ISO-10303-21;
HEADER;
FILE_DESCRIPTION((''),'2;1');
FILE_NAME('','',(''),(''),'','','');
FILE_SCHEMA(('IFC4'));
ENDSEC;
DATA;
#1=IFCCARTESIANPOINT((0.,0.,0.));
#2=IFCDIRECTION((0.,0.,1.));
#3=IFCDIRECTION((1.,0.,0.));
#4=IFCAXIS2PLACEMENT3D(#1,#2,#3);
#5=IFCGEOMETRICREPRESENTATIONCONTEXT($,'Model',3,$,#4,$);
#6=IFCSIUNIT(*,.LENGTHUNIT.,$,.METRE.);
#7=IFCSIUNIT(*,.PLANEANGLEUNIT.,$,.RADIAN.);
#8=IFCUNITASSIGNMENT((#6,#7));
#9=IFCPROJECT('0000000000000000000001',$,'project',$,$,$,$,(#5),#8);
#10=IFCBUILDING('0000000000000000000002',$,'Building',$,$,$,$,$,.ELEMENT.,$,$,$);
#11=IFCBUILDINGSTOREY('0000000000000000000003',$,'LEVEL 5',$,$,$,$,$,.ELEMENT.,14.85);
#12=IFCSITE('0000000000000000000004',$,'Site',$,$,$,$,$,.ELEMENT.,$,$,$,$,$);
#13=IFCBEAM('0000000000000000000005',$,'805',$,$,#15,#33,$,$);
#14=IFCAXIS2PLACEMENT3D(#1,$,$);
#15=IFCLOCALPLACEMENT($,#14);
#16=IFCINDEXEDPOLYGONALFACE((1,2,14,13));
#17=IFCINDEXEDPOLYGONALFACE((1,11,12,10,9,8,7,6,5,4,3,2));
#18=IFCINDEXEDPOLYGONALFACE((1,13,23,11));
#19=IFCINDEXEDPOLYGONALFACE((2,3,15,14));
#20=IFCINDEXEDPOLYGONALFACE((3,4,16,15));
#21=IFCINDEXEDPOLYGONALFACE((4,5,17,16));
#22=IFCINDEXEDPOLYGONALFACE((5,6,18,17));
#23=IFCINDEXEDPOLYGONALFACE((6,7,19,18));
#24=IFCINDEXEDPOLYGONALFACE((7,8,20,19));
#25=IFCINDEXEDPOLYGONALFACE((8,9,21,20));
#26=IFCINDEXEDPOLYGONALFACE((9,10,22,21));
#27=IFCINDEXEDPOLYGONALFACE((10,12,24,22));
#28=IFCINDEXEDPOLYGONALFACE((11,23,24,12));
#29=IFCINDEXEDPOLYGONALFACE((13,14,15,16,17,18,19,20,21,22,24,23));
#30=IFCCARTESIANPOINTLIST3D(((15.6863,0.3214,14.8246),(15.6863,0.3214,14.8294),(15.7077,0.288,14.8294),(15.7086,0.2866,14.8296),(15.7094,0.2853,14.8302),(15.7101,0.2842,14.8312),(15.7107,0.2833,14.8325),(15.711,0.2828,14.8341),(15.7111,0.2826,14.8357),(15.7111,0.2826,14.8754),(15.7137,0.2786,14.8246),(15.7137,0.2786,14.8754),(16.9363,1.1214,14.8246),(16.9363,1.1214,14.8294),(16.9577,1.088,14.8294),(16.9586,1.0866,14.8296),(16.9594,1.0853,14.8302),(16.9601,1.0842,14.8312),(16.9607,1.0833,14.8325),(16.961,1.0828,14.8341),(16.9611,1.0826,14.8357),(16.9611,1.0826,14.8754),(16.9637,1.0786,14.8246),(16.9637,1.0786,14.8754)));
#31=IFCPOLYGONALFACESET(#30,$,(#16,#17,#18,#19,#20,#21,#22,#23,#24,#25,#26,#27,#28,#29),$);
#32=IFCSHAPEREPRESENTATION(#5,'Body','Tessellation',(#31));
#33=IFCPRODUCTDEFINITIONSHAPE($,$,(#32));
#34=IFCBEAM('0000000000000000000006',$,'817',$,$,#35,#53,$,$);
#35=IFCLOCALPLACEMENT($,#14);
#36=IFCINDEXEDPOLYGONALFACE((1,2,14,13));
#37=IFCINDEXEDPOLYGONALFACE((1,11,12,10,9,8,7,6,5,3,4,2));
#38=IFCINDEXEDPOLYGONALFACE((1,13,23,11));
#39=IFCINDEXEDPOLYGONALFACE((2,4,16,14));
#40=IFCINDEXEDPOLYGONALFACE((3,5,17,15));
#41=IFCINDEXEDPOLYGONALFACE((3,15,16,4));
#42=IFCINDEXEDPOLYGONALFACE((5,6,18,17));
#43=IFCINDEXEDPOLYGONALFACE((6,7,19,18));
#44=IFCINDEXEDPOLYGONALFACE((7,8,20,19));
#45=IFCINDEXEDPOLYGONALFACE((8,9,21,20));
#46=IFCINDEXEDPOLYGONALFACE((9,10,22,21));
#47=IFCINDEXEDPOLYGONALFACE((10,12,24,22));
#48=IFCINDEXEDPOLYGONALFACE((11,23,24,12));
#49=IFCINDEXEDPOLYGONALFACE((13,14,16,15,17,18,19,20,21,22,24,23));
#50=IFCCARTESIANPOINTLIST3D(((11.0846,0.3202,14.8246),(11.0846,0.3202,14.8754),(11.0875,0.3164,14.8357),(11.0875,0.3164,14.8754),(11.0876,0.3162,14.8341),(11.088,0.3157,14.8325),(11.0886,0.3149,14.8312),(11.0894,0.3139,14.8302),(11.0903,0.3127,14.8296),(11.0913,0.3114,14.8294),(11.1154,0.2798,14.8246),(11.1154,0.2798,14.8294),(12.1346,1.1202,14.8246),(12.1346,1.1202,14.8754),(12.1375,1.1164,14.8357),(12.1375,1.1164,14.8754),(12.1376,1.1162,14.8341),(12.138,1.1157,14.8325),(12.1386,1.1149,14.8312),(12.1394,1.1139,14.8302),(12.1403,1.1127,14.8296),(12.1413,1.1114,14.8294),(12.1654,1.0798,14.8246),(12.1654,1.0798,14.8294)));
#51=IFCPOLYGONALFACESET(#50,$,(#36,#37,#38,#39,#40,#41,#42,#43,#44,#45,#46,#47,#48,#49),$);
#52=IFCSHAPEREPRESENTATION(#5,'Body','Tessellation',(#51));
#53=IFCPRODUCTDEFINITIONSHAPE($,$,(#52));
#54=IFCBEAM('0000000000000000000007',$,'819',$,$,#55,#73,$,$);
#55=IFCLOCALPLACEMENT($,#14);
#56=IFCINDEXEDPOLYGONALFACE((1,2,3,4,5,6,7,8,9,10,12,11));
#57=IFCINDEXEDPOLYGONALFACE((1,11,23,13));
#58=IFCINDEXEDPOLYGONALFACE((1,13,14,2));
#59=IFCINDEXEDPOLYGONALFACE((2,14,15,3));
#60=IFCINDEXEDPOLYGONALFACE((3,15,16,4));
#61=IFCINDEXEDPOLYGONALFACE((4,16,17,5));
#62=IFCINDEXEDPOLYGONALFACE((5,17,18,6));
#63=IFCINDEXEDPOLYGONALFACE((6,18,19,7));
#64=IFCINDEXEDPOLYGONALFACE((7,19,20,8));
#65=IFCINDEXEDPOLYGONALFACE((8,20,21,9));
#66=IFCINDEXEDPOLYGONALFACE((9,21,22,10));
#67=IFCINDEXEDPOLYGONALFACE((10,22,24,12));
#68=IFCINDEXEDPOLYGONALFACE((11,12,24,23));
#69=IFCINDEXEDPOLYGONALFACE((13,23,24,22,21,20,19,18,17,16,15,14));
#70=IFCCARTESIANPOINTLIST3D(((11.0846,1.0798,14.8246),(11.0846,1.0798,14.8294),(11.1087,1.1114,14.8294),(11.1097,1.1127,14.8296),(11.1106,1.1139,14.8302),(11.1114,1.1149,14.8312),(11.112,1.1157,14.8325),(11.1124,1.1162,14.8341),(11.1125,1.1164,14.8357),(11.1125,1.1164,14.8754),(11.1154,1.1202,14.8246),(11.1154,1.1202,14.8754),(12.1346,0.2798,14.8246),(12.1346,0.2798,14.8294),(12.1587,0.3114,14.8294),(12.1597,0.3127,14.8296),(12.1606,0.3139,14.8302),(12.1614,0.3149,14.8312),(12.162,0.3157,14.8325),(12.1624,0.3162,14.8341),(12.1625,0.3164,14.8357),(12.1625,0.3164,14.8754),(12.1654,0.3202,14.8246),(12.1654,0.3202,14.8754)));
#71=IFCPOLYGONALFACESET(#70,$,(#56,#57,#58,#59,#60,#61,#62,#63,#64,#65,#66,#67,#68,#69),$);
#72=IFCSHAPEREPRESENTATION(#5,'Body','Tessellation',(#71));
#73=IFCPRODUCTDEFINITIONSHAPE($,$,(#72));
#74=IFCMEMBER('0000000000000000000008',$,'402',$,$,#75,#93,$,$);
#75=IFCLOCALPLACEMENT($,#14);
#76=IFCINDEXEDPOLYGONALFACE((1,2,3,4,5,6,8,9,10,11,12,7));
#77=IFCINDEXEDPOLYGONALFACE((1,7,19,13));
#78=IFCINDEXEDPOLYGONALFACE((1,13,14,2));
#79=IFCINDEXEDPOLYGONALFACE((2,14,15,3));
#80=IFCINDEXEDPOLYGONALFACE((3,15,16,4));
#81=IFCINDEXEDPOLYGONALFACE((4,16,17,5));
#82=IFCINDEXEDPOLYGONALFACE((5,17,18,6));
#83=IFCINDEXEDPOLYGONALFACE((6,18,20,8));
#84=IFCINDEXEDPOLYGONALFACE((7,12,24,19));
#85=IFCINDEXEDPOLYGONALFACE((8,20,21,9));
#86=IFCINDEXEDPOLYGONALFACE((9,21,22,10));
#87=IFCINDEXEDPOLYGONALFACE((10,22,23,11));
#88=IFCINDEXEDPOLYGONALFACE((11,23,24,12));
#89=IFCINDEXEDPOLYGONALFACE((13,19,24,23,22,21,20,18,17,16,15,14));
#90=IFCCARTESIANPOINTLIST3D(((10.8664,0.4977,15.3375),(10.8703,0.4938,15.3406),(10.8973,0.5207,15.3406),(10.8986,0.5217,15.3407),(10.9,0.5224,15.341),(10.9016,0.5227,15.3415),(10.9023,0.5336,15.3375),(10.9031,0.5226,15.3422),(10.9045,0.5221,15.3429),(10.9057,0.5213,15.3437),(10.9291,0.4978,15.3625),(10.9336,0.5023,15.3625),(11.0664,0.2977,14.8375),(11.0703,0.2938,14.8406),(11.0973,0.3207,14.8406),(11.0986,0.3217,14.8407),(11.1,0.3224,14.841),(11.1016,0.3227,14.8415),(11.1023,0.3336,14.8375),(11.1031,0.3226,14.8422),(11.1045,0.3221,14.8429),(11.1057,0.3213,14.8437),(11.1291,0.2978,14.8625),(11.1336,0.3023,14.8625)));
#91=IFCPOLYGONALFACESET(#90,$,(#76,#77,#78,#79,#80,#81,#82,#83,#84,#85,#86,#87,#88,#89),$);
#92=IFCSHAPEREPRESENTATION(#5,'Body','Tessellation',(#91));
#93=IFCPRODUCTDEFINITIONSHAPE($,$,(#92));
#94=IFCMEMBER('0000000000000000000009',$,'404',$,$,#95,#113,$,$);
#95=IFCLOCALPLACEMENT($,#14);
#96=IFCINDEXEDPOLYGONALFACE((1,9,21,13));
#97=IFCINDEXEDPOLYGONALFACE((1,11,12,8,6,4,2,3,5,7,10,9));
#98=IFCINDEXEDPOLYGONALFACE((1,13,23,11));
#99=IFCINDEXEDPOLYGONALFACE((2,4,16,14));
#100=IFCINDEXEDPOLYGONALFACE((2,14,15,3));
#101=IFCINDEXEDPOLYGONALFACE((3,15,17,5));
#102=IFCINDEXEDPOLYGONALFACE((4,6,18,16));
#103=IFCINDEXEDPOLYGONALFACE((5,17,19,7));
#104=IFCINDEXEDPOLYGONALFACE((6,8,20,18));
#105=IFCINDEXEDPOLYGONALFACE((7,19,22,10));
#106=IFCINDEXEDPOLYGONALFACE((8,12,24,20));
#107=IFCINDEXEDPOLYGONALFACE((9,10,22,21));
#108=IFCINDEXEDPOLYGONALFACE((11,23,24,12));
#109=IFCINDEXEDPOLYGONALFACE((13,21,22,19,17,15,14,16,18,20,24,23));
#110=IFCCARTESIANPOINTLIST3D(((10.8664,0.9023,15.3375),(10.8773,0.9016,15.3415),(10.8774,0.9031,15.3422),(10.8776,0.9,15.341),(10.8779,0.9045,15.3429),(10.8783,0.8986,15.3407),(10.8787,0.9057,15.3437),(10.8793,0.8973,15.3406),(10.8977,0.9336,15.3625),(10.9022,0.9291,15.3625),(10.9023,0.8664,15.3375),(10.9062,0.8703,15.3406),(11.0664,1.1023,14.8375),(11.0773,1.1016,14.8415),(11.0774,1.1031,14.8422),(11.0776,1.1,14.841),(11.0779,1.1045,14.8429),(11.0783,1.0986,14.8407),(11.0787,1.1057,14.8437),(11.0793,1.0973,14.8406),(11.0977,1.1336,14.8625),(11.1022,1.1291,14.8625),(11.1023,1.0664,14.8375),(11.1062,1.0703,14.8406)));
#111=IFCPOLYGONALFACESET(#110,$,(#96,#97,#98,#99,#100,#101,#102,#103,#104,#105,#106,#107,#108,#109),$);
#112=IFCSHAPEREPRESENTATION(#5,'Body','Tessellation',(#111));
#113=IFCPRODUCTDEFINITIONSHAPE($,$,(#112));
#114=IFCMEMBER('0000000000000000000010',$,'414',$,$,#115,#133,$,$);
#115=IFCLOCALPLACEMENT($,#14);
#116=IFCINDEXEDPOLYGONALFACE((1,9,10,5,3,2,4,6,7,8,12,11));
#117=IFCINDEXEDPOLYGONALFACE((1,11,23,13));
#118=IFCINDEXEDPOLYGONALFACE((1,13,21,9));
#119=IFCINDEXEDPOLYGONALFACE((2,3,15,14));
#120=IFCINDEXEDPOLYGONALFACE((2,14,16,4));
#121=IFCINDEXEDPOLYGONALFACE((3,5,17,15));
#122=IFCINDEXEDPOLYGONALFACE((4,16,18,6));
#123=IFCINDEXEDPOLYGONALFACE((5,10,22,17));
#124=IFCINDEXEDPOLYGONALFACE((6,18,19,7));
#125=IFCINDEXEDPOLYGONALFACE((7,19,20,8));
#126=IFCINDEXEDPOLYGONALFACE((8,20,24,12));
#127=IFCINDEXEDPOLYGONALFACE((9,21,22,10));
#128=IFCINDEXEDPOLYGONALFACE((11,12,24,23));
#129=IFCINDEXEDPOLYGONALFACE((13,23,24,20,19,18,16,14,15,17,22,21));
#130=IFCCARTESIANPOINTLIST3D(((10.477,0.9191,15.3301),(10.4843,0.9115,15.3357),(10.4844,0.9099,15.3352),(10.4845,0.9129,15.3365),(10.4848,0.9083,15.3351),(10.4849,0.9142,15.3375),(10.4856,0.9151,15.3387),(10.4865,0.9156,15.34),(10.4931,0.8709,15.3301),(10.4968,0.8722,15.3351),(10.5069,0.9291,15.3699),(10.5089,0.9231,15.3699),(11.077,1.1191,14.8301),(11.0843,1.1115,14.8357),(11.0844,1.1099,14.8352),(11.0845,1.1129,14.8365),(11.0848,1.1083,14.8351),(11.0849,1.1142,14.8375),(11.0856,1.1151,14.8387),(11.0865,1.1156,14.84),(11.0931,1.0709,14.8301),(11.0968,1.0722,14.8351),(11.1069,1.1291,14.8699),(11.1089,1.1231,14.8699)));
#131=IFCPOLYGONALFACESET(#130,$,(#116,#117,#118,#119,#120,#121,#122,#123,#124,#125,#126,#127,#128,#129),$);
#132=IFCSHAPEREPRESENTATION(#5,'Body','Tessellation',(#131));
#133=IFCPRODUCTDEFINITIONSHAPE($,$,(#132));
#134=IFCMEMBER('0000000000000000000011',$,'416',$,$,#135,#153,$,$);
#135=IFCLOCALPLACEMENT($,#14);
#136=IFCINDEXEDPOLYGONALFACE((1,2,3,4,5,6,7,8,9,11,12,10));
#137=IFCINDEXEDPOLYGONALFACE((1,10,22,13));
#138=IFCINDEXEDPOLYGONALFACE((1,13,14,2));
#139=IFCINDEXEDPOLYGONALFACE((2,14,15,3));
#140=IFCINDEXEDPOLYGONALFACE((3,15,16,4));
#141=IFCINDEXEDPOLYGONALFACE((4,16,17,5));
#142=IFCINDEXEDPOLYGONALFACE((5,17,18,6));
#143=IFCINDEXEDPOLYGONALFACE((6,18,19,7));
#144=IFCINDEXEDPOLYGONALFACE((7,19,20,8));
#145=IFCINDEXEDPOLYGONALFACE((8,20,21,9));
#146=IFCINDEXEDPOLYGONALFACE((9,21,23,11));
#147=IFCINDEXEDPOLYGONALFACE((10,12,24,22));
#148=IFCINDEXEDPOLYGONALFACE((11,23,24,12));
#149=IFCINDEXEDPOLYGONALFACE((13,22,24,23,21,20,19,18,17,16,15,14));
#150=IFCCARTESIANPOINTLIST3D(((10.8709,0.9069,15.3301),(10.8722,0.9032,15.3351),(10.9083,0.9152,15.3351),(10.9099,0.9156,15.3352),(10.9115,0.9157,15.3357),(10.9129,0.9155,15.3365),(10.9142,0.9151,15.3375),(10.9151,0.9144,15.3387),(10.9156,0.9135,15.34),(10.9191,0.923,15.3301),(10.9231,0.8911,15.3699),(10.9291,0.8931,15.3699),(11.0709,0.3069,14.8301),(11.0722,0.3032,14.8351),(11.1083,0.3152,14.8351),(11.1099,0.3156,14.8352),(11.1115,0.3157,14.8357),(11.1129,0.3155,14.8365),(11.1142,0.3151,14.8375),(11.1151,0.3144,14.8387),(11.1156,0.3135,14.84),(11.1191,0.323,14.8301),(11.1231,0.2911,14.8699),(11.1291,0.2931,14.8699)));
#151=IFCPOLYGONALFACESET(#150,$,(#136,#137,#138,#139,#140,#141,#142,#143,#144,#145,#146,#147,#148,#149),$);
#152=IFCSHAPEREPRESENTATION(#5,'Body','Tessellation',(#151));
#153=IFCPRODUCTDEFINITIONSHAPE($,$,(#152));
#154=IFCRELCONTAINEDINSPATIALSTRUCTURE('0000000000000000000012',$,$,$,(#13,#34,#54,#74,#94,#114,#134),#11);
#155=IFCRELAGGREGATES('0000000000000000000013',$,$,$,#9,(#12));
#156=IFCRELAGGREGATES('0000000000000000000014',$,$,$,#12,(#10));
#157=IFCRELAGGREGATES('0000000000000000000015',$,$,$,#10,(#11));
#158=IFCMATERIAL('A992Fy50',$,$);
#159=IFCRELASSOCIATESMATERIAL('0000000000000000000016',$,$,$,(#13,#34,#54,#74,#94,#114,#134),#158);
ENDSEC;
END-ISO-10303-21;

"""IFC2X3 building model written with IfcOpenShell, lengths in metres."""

from ifc_helpers import new_model, si_unit, frame, origin_with_axes, origin_2d_with_axis, place, context, project, spatial, l_section, extrude, material, element, save


model = new_model("IFC2X3")

# Units and contexts
model_context = context("Model", 3, world=origin_with_axes())
ifc_project = project(units=[si_unit("LENGTHUNIT", "METRE"), si_unit("PLANEANGLEUNIT", "RADIAN")], contexts=[model_context])

# Site, building, storey
site = spatial("IfcSite", under=ifc_project, Name="Site", CompositionType="ELEMENT")
building = spatial("IfcBuilding", under=site, Name="Building", CompositionType="ELEMENT")
storey = spatial("IfcBuildingStorey", under=building, Name="LEVEL 5", CompositionType="ELEMENT", Elevation=14.85)

# Beams
ifc_material = material(Name="A992Fy50")
for number, where, z_axis, x_axis, name in (
    (1, (15.7, 0.3, 14.85), (0.842271, 0.539054, 0.0), (-0.539054, 0.842271, 0.0), "805"),
):
    element("IfcBeam", number, at=place(None, frame(where, z_axis=z_axis, x_axis=x_axis)), inside=storey, material=ifc_material, Name=name, context=model_context, shape_type="SweptSolid", body=[
        extrude(l_section(Depth=0.0508, Width=0.0508, Thickness=0.0048, FilletRadius=0.0063, at=origin_2d_with_axis()), origin_with_axes(), (0.0, 0.0, 1.0), 1.4841),
    ])
for number, where, z_axis, x_axis, name in (
    (2, (12.15, 1.1, 14.85), (-0.795432, -0.606043, 0.0), (0.606043, -0.795432, 0.0), "817"),
    (3, (12.15, 0.3, 14.85), (-0.795432, 0.606043, 0.0), (-0.606043, -0.795432, 0.0), "819"),
):
    element("IfcBeam", number, at=place(None, frame(where, z_axis=z_axis, x_axis=x_axis)), inside=storey, material=ifc_material, Name=name, context=model_context, shape_type="SweptSolid", body=[
        extrude(l_section(Depth=0.0508, Width=0.0508, Thickness=0.0048, FilletRadius=0.0063, at=origin_2d_with_axis()), origin_with_axes(), (0.0, 0.0, 1.0), 1.32),
    ])

# Members
for number, where, z_axis, x_axis, name in (
    (4, (11.1, 0.3, 14.85), (-0.348155, 0.348155, 0.870388), (-0.707107, -0.707107, 0.0), "402"),
    (5, (11.1, 1.1, 14.85), (-0.348155, -0.348155, 0.870388), (0.707107, -0.707107, 0.0), "404"),
):
    element("IfcMember", number, at=place(None, frame(where, z_axis=z_axis, x_axis=x_axis)), inside=storey, material=ifc_material, Name=name, context=model_context, shape_type="SweptSolid", body=[
        extrude(l_section(Depth=0.0508, Width=0.0508, Thickness=0.0063, FilletRadius=0.0063, at=origin_2d_with_axis()), origin_with_axes(), (0.0, 0.0, 1.0), 0.5745),
    ])
for number, where, z_axis, x_axis, name in (
    (6, (11.1, 1.1, 14.85), (-0.744208, -0.248069, 0.620174), (0.316228, -0.948683, 0.0), "414"),
    (7, (11.1, 0.3, 14.85), (-0.248069, 0.744208, 0.620174), (-0.948683, -0.316228, 0.0), "416"),
):
    element("IfcMember", number, at=place(None, frame(where, z_axis=z_axis, x_axis=x_axis)), inside=storey, material=ifc_material, Name=name, context=model_context, shape_type="SweptSolid", body=[
        extrude(l_section(Depth=0.0508, Width=0.0508, Thickness=0.0063, FilletRadius=0.0063, at=origin_2d_with_axis()), origin_with_axes(), (0.0, 0.0, 1.0), 0.8062),
    ])

save(model, "model.ifc")
